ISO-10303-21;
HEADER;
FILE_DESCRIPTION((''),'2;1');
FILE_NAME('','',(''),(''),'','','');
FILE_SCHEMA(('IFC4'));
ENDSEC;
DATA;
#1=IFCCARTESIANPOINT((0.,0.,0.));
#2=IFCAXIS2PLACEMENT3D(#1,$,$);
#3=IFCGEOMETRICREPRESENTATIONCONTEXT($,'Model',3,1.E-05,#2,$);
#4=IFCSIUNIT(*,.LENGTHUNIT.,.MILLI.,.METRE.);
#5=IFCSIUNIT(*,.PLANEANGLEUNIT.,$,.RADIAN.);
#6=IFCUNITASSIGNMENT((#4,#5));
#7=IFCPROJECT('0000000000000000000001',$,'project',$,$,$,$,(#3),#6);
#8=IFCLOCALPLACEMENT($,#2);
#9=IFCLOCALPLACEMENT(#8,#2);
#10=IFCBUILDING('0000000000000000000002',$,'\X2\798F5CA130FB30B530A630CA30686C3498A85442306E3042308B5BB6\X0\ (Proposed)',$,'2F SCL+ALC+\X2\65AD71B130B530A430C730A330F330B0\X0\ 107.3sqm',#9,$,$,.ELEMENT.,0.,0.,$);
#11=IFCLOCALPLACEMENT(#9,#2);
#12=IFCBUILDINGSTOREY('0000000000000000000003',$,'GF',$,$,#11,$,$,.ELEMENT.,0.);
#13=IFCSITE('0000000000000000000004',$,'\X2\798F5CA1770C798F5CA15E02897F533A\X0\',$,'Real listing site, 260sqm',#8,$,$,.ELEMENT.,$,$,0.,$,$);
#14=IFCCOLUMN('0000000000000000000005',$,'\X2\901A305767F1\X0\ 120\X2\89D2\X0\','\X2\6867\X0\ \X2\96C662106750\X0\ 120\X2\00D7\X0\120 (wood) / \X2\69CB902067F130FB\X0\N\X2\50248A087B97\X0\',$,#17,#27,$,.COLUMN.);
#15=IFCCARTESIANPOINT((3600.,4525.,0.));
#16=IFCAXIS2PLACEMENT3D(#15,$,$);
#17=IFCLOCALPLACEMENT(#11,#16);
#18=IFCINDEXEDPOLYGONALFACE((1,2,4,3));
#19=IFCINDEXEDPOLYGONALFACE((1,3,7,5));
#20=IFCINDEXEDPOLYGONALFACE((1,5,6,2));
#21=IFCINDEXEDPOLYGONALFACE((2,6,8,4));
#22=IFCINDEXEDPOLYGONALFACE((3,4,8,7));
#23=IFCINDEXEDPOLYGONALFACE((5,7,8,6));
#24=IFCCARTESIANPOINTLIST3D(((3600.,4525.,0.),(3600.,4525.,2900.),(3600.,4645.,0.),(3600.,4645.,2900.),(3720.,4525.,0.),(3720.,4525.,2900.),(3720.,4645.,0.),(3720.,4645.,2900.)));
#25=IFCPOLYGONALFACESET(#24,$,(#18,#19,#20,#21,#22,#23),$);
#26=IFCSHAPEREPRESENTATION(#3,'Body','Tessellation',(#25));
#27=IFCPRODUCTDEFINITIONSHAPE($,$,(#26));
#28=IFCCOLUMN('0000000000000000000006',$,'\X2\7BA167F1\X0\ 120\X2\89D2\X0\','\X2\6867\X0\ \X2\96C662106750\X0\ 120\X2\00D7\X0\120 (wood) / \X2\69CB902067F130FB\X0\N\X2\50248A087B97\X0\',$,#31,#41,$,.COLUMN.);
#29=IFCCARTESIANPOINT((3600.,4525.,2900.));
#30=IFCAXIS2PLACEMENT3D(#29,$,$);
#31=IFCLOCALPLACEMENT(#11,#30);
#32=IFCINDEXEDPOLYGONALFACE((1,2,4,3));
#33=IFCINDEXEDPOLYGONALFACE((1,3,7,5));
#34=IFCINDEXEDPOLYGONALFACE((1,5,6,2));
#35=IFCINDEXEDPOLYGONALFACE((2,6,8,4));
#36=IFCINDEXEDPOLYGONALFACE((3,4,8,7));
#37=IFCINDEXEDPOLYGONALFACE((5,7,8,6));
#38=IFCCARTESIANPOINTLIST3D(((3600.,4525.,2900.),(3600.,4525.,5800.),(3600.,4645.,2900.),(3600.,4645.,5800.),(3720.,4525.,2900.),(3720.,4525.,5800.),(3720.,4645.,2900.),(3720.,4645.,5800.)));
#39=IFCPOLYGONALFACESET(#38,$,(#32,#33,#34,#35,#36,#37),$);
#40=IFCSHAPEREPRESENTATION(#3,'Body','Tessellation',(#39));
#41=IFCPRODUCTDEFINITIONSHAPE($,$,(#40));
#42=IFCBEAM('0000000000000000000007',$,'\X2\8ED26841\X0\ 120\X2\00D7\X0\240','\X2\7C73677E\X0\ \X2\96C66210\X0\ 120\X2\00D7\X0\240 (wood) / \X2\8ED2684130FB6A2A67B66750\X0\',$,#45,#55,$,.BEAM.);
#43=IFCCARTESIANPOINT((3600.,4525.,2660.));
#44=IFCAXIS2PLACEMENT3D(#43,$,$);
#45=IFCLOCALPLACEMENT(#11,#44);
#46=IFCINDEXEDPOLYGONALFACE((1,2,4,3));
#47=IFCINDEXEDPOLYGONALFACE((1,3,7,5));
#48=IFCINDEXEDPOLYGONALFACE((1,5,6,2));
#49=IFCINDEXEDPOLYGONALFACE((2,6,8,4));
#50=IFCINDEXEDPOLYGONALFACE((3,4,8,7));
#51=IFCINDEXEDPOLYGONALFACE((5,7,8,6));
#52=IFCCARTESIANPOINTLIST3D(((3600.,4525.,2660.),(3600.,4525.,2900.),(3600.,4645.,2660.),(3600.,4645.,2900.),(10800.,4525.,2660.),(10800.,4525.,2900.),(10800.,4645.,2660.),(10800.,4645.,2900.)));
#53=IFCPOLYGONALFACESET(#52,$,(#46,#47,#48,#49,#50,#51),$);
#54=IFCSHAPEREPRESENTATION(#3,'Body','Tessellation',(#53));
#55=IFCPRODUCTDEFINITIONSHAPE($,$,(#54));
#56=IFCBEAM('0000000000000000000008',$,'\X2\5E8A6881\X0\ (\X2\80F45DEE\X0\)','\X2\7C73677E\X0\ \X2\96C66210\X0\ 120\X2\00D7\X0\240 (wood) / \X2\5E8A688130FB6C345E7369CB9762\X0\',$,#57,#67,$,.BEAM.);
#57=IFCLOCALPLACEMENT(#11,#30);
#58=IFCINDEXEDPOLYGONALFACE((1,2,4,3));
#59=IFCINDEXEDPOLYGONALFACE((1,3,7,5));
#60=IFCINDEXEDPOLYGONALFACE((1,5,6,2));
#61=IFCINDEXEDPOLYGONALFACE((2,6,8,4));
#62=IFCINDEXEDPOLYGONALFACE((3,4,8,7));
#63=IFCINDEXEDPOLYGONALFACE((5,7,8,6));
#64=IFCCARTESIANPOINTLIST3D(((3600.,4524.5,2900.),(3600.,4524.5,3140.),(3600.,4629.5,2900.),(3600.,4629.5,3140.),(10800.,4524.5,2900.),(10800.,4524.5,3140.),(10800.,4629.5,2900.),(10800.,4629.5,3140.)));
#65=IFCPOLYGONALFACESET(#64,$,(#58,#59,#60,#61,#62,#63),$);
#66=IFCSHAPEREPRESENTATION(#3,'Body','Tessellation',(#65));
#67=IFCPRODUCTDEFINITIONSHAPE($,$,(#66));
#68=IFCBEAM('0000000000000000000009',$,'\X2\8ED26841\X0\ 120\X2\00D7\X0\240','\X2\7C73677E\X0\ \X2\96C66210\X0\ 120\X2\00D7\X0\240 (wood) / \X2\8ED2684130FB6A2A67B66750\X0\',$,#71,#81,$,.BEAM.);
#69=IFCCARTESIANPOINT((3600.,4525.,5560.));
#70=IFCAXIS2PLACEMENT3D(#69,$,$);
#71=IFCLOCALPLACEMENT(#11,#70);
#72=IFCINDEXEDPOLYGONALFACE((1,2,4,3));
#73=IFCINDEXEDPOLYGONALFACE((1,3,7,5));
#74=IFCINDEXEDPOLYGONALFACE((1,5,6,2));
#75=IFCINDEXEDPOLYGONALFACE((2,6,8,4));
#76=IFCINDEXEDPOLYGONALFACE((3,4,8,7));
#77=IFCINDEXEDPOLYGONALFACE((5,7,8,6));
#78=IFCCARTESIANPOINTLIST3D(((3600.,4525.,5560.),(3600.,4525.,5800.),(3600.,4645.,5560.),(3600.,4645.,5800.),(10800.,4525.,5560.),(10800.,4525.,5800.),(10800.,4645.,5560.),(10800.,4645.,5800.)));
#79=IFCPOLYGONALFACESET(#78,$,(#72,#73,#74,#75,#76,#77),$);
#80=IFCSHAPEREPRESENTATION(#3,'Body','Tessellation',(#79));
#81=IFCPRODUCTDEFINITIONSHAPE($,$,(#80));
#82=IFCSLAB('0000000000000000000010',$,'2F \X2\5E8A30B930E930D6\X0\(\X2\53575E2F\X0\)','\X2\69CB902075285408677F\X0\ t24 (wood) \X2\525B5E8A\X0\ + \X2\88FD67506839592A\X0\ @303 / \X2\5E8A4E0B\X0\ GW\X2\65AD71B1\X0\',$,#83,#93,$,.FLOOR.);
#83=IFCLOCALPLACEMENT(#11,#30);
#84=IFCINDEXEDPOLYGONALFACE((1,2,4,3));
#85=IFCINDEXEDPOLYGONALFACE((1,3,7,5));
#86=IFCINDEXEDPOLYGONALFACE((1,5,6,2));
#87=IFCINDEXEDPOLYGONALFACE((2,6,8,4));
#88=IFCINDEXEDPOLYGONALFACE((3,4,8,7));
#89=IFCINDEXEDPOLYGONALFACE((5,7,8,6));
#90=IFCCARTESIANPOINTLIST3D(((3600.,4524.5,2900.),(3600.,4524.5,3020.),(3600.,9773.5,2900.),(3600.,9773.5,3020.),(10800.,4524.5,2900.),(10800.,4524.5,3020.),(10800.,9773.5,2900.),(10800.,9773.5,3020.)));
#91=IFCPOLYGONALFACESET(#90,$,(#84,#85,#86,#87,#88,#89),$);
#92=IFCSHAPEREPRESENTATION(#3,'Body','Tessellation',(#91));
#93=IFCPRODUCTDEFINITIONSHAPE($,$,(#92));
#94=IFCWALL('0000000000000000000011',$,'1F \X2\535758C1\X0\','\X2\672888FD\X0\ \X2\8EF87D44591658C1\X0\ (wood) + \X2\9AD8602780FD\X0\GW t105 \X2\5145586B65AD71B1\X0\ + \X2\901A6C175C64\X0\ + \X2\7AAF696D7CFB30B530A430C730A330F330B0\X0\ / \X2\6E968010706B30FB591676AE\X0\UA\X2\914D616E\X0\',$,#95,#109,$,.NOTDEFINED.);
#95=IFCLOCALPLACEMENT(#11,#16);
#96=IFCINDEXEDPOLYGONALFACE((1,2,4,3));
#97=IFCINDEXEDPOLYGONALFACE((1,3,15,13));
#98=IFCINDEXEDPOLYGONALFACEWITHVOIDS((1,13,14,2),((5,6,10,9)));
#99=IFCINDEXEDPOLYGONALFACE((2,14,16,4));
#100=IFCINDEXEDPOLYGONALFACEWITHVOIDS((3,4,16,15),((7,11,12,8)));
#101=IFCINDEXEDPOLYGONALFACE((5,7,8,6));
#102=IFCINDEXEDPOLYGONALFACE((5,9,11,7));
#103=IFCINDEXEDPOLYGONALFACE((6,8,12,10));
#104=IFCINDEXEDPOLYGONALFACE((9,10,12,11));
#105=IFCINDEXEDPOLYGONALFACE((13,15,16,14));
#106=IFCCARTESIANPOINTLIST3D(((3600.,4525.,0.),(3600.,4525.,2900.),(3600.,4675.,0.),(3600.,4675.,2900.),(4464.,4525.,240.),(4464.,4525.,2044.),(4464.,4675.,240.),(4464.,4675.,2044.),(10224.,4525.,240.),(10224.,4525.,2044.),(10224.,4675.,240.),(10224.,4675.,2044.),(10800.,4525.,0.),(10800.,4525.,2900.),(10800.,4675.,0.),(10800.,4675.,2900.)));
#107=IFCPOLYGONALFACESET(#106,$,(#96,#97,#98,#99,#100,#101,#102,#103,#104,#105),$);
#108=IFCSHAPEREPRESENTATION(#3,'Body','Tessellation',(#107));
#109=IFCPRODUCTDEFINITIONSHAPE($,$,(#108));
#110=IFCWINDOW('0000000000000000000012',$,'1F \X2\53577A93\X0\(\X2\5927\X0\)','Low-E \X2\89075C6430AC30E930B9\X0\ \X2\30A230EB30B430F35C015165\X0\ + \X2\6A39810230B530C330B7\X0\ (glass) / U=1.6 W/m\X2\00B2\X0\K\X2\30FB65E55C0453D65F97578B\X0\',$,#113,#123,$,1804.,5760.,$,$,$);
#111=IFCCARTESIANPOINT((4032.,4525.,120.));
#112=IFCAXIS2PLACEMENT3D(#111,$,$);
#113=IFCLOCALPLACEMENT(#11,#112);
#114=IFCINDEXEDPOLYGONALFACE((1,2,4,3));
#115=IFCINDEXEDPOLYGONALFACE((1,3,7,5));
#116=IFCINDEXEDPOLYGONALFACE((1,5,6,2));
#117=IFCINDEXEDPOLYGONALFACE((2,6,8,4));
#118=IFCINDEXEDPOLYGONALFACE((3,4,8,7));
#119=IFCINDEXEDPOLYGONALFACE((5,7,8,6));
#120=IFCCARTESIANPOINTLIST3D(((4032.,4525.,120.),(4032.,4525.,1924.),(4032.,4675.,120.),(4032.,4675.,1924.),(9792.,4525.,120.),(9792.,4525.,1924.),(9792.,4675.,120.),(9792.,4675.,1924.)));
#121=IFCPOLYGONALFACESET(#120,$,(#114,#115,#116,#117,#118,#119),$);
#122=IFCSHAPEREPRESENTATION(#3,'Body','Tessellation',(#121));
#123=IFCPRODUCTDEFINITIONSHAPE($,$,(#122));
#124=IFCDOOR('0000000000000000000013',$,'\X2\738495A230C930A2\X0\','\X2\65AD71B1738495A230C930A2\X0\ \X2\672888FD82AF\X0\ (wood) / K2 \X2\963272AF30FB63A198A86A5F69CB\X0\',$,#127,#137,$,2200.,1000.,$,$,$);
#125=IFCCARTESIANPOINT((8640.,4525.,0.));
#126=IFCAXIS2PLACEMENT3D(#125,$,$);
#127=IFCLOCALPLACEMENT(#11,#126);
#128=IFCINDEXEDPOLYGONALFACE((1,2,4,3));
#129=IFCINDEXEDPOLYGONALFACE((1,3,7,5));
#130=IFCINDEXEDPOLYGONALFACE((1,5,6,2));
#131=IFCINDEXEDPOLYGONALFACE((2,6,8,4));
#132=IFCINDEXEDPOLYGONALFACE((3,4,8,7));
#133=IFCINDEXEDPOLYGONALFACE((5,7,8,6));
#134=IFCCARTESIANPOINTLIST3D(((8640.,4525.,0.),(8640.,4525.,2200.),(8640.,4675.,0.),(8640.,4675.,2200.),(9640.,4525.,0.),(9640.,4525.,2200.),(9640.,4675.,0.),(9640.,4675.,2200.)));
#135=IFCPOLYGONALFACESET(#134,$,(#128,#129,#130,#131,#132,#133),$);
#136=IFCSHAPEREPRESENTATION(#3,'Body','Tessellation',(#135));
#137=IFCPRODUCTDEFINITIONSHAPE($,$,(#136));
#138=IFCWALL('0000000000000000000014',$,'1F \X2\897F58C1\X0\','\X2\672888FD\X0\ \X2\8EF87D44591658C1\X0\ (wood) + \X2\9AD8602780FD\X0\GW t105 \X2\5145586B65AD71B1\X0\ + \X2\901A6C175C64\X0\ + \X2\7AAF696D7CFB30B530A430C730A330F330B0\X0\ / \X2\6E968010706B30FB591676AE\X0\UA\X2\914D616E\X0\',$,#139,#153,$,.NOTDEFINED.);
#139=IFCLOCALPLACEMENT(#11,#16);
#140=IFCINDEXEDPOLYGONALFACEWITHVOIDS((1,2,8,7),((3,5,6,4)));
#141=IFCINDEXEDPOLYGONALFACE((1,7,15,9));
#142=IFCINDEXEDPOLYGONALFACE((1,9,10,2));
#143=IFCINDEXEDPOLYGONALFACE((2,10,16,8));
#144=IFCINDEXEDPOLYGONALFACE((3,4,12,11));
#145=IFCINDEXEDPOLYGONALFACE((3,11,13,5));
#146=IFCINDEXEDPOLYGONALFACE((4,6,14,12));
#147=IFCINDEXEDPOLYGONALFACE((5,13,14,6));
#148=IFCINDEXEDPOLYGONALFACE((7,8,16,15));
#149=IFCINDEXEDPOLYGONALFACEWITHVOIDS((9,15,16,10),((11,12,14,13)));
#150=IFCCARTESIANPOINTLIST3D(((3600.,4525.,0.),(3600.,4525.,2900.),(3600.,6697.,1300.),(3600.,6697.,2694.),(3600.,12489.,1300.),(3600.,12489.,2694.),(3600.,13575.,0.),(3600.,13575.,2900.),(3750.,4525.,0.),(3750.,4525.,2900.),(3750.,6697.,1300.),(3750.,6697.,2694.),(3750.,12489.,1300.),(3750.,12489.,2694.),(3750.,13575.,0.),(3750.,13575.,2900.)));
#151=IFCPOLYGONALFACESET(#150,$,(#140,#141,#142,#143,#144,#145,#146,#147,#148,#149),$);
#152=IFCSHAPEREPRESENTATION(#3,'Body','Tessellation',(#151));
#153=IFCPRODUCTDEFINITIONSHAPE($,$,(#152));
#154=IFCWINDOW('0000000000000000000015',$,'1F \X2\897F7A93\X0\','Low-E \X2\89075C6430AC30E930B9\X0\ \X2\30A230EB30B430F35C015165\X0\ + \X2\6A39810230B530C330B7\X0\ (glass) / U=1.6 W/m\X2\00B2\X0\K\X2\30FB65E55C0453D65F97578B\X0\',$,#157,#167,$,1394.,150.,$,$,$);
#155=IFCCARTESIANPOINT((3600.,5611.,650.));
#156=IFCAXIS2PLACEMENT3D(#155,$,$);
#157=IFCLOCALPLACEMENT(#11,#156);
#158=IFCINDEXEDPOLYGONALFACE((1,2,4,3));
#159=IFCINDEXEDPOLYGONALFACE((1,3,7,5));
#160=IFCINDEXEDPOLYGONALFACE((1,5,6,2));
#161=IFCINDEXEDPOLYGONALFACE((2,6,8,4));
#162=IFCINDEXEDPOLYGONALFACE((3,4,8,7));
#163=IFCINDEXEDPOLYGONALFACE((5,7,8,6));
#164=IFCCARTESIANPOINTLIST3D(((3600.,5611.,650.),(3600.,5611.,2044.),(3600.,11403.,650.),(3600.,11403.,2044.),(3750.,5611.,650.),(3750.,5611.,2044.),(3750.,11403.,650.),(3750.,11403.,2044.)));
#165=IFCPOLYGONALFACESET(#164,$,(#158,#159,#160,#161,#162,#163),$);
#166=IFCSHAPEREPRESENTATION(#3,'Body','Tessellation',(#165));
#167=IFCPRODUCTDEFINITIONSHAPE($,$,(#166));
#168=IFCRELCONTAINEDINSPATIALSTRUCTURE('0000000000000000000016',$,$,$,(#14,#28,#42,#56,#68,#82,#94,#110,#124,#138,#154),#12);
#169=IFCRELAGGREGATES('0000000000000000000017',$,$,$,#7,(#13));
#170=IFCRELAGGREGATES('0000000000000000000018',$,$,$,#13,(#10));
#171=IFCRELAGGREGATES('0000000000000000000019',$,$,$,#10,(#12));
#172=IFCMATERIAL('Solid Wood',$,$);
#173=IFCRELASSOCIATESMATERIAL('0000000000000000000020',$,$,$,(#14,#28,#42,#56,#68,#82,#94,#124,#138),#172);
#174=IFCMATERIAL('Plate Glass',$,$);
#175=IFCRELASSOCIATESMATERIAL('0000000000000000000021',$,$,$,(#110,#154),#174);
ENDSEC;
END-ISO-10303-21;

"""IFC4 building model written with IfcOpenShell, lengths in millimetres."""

from ifc_helpers import new_model, si_unit, frame, frame_2d, origin, place, context, project, spatial, rectangle, extrude, material, element, fill, save


model = new_model("IFC4")

# Units and contexts
model_context = context("Model", 3, precision=1e-05, world=origin())
ifc_project = project(units=[si_unit("LENGTHUNIT", "METRE", prefix="MILLI"), si_unit("PLANEANGLEUNIT", "RADIAN")], contexts=[model_context])

# Site, building, storey
site_placement = place(None, origin())
site = spatial("IfcSite", under=ifc_project, at=site_placement, Name="福岡県福岡市西区", ObjectType="Real listing site, 260sqm", CompositionType="ELEMENT", RefElevation=0.0)
building_placement = place(site_placement, origin())
building = spatial("IfcBuilding", under=site, at=building_placement, Name="福岡・サウナと水風呂のある家 (Proposed)", ObjectType="2F SCL+ALC+断熱サイディング 107.3sqm", CompositionType="ELEMENT", ElevationOfRefHeight=0.0, ElevationOfTerrain=0.0)
storey_placement = place(building_placement, origin())
storey = spatial("IfcBuildingStorey", under=building, at=storey_placement, Name="GF", CompositionType="ELEMENT", Elevation=0.0)

# Columns
ifc_material_1 = material(Name="Solid Wood")
column_1_placement = place(storey_placement, frame((3600.0, 4525.0, 0.0)))
element("IfcColumn", 1, at=column_1_placement, inside=storey, material=ifc_material_1, Name="通し柱 120角", Description="桧 集成材 120×120 (wood) / 構造柱・N値計算", PredefinedType="COLUMN", context=model_context, shape_type="SweptSolid", body=[
    extrude(rectangle(XDim=120.0, YDim=120.0, at=frame_2d((60.0, 60.0))), frame((3600.0, 4525.0, 0.0)), (0.0, 0.0, 1.0), 2900.0),
])
column_2_placement = place(storey_placement, frame((3600.0, 4525.0, 2900.0)))
element("IfcColumn", 2, at=column_2_placement, inside=storey, material=ifc_material_1, Name="管柱 120角", Description="桧 集成材 120×120 (wood) / 構造柱・N値計算", PredefinedType="COLUMN", context=model_context, shape_type="SweptSolid", body=[
    extrude(rectangle(XDim=120.0, YDim=120.0, at=frame_2d((60.0, 60.0))), frame((3600.0, 4525.0, 2900.0)), (0.0, 0.0, 1.0), 2900.0),
])

# Beams
beam_1_placement = place(storey_placement, frame((3600.0, 4525.0, 2660.0)))
element("IfcBeam", 3, at=beam_1_placement, inside=storey, material=ifc_material_1, Name="軒桁 120×240", Description="米松 集成 120×240 (wood) / 軒桁・横架材", PredefinedType="BEAM", context=model_context, shape_type="SweptSolid", body=[
    extrude(rectangle(XDim=7200.0, YDim=120.0, at=frame_2d((3600.0, 60.0))), frame((3600.0, 4525.0, 2660.0)), (0.0, 0.0, 1.0), 240.0),
])
beam_2_placement = place(storey_placement, frame((3600.0, 4525.0, 2900.0)))
element("IfcBeam", 4, at=beam_2_placement, inside=storey, material=ifc_material_1, Name="床梁 (胴差)", Description="米松 集成 120×240 (wood) / 床梁・水平構面", PredefinedType="BEAM", context=model_context, shape_type="SweptSolid", body=[
    extrude(rectangle(XDim=7200.0, YDim=105.0, at=frame_2d((3600.0, 52.0))), frame((3600.0, 4525.0, 2900.0)), (0.0, 0.0, 1.0), 240.0),
])
beam_3_placement = place(storey_placement, frame((3600.0, 4525.0, 5560.0)))
element("IfcBeam", 5, at=beam_3_placement, inside=storey, material=ifc_material_1, Name="軒桁 120×240", Description="米松 集成 120×240 (wood) / 軒桁・横架材", PredefinedType="BEAM", context=model_context, shape_type="SweptSolid", body=[
    extrude(rectangle(XDim=7200.0, YDim=120.0, at=frame_2d((3600.0, 60.0))), frame((3600.0, 4525.0, 5560.0)), (0.0, 0.0, 1.0), 240.0),
])

# Slab
slab_1_placement = place(storey_placement, frame((3600.0, 4525.0, 2900.0)))
element("IfcSlab", 6, at=slab_1_placement, inside=storey, material=ifc_material_1, Name="2F 床スラブ(南帯)", Description="構造用合板 t24 (wood) 剛床 + 製材根太 @303 / 床下 GW断熱", PredefinedType="FLOOR", context=model_context, shape_type="SweptSolid", body=[
    extrude(rectangle(XDim=7200.0, YDim=5249.0, at=frame_2d((3600.0, 2624.0))), frame((3600.0, 4525.0, 2900.0)), (0.0, 0.0, 1.0), 120.0),
])

# Wall, openings, window, door
wall_1_placement = place(storey_placement, frame((3600.0, 4525.0, 0.0)))
wall_1 = element("IfcWall", 7, at=wall_1_placement, inside=storey, material=ifc_material_1, Name="1F 南壁", Description="木製 軸組外壁 (wood) + 高性能GW t105 充填断熱 + 通気層 + 窯業系サイディング / 準耐火・外皮UA配慮", PredefinedType="NOTDEFINED", context=model_context, shape_type="SweptSolid", body=[
    extrude(rectangle(XDim=7200.0, YDim=150.0, at=frame_2d((3600.0, 75.0))), frame((3600.0, 4525.0, 0.0)), (0.0, 0.0, 1.0), 2900.0),
])
opening_1_placement = place(storey_placement, frame((4032.0, 4525.0, 120.0)))
opening_1 = element("IfcOpeningElement", 8, at=opening_1_placement, cuts=wall_1, PredefinedType="NOTDEFINED", context=model_context, shape_type="SweptSolid", body=[
    extrude(rectangle(XDim=5760.0, YDim=150.0, at=frame_2d((2880.0, 75.0))), frame((4032.0, 4525.0, 120.0)), (0.0, 0.0, 1.0), 1804.0),
])
opening_2_placement = place(storey_placement, frame((8640.0, 4525.0, 0.0)))
opening_2 = element("IfcOpeningElement", 9, at=opening_2_placement, cuts=wall_1, PredefinedType="NOTDEFINED", context=model_context, shape_type="SweptSolid", body=[
    extrude(rectangle(XDim=1000.0, YDim=150.0, at=frame_2d((500.0, 75.0))), frame((8640.0, 4525.0, 0.0)), (0.0, 0.0, 1.0), 2200.0),
])
ifc_material_2 = material(Name="Plate Glass")
window_1_placement = place(storey_placement, frame((4032.0, 4525.0, 120.0)))
window_1 = element("IfcWindow", 10, at=window_1_placement, inside=storey, material=ifc_material_2, Name="1F 南窓(大)", Description="Low-E 複層ガラス アルゴン封入 + 樹脂サッシ (glass) / U=1.6 W/m²K・日射取得型", OverallHeight=1804.0, OverallWidth=5760.0, context=model_context, shape_type="SweptSolid", body=[
    extrude(rectangle(XDim=5760.0, YDim=150.0, at=frame_2d((2880.0, 75.0))), frame((4032.0, 4525.0, 120.0)), (0.0, 0.0, 1.0), 1804.0),
])
fill(opening_1, window_1)
door_placement = place(storey_placement, frame((8640.0, 4525.0, 0.0)))
door = element("IfcDoor", 11, at=door_placement, inside=storey, material=ifc_material_1, Name="玄関ドア", Description="断熱玄関ドア 木製芯 (wood) / K2 防犯・採風機構", OverallHeight=2200.0, OverallWidth=1000.0, context=model_context, shape_type="SweptSolid", body=[
    extrude(rectangle(XDim=1000.0, YDim=150.0, at=frame_2d((500.0, 75.0))), frame((8640.0, 4525.0, 0.0)), (0.0, 0.0, 1.0), 2200.0),
])
fill(opening_2, door)

# Wall, opening, window
wall_2_placement = place(storey_placement, frame((3600.0, 4525.0, 0.0)))
wall_2 = element("IfcWall", 12, at=wall_2_placement, inside=storey, material=ifc_material_1, Name="1F 西壁", Description="木製 軸組外壁 (wood) + 高性能GW t105 充填断熱 + 通気層 + 窯業系サイディング / 準耐火・外皮UA配慮", PredefinedType="NOTDEFINED", context=model_context, shape_type="SweptSolid", body=[
    extrude(rectangle(XDim=150.0, YDim=9050.0, at=frame_2d((75.0, 4525.0))), frame((3600.0, 4525.0, 0.0)), (0.0, 0.0, 1.0), 2900.0),
])
opening_3_placement = place(storey_placement, frame((3600.0, 5611.0, 650.0)))
opening_3 = element("IfcOpeningElement", 13, at=opening_3_placement, cuts=wall_2, PredefinedType="NOTDEFINED", context=model_context, shape_type="SweptSolid", body=[
    extrude(rectangle(XDim=150.0, YDim=5792.0, at=frame_2d((75.0, 2896.0))), frame((3600.0, 5611.0, 650.0)), (0.0, 0.0, 1.0), 1394.0),
])
window_2_placement = place(storey_placement, frame((3600.0, 5611.0, 650.0)))
window_2 = element("IfcWindow", 14, at=window_2_placement, inside=storey, material=ifc_material_2, Name="1F 西窓", Description="Low-E 複層ガラス アルゴン封入 + 樹脂サッシ (glass) / U=1.6 W/m²K・日射取得型", OverallHeight=1394.0, OverallWidth=150.0, context=model_context, shape_type="SweptSolid", body=[
    extrude(rectangle(XDim=150.0, YDim=5792.0, at=frame_2d((75.0, 2896.0))), frame((3600.0, 5611.0, 650.0)), (0.0, 0.0, 1.0), 1394.0),
])
fill(opening_3, window_2)

save(model, "model.ifc")
